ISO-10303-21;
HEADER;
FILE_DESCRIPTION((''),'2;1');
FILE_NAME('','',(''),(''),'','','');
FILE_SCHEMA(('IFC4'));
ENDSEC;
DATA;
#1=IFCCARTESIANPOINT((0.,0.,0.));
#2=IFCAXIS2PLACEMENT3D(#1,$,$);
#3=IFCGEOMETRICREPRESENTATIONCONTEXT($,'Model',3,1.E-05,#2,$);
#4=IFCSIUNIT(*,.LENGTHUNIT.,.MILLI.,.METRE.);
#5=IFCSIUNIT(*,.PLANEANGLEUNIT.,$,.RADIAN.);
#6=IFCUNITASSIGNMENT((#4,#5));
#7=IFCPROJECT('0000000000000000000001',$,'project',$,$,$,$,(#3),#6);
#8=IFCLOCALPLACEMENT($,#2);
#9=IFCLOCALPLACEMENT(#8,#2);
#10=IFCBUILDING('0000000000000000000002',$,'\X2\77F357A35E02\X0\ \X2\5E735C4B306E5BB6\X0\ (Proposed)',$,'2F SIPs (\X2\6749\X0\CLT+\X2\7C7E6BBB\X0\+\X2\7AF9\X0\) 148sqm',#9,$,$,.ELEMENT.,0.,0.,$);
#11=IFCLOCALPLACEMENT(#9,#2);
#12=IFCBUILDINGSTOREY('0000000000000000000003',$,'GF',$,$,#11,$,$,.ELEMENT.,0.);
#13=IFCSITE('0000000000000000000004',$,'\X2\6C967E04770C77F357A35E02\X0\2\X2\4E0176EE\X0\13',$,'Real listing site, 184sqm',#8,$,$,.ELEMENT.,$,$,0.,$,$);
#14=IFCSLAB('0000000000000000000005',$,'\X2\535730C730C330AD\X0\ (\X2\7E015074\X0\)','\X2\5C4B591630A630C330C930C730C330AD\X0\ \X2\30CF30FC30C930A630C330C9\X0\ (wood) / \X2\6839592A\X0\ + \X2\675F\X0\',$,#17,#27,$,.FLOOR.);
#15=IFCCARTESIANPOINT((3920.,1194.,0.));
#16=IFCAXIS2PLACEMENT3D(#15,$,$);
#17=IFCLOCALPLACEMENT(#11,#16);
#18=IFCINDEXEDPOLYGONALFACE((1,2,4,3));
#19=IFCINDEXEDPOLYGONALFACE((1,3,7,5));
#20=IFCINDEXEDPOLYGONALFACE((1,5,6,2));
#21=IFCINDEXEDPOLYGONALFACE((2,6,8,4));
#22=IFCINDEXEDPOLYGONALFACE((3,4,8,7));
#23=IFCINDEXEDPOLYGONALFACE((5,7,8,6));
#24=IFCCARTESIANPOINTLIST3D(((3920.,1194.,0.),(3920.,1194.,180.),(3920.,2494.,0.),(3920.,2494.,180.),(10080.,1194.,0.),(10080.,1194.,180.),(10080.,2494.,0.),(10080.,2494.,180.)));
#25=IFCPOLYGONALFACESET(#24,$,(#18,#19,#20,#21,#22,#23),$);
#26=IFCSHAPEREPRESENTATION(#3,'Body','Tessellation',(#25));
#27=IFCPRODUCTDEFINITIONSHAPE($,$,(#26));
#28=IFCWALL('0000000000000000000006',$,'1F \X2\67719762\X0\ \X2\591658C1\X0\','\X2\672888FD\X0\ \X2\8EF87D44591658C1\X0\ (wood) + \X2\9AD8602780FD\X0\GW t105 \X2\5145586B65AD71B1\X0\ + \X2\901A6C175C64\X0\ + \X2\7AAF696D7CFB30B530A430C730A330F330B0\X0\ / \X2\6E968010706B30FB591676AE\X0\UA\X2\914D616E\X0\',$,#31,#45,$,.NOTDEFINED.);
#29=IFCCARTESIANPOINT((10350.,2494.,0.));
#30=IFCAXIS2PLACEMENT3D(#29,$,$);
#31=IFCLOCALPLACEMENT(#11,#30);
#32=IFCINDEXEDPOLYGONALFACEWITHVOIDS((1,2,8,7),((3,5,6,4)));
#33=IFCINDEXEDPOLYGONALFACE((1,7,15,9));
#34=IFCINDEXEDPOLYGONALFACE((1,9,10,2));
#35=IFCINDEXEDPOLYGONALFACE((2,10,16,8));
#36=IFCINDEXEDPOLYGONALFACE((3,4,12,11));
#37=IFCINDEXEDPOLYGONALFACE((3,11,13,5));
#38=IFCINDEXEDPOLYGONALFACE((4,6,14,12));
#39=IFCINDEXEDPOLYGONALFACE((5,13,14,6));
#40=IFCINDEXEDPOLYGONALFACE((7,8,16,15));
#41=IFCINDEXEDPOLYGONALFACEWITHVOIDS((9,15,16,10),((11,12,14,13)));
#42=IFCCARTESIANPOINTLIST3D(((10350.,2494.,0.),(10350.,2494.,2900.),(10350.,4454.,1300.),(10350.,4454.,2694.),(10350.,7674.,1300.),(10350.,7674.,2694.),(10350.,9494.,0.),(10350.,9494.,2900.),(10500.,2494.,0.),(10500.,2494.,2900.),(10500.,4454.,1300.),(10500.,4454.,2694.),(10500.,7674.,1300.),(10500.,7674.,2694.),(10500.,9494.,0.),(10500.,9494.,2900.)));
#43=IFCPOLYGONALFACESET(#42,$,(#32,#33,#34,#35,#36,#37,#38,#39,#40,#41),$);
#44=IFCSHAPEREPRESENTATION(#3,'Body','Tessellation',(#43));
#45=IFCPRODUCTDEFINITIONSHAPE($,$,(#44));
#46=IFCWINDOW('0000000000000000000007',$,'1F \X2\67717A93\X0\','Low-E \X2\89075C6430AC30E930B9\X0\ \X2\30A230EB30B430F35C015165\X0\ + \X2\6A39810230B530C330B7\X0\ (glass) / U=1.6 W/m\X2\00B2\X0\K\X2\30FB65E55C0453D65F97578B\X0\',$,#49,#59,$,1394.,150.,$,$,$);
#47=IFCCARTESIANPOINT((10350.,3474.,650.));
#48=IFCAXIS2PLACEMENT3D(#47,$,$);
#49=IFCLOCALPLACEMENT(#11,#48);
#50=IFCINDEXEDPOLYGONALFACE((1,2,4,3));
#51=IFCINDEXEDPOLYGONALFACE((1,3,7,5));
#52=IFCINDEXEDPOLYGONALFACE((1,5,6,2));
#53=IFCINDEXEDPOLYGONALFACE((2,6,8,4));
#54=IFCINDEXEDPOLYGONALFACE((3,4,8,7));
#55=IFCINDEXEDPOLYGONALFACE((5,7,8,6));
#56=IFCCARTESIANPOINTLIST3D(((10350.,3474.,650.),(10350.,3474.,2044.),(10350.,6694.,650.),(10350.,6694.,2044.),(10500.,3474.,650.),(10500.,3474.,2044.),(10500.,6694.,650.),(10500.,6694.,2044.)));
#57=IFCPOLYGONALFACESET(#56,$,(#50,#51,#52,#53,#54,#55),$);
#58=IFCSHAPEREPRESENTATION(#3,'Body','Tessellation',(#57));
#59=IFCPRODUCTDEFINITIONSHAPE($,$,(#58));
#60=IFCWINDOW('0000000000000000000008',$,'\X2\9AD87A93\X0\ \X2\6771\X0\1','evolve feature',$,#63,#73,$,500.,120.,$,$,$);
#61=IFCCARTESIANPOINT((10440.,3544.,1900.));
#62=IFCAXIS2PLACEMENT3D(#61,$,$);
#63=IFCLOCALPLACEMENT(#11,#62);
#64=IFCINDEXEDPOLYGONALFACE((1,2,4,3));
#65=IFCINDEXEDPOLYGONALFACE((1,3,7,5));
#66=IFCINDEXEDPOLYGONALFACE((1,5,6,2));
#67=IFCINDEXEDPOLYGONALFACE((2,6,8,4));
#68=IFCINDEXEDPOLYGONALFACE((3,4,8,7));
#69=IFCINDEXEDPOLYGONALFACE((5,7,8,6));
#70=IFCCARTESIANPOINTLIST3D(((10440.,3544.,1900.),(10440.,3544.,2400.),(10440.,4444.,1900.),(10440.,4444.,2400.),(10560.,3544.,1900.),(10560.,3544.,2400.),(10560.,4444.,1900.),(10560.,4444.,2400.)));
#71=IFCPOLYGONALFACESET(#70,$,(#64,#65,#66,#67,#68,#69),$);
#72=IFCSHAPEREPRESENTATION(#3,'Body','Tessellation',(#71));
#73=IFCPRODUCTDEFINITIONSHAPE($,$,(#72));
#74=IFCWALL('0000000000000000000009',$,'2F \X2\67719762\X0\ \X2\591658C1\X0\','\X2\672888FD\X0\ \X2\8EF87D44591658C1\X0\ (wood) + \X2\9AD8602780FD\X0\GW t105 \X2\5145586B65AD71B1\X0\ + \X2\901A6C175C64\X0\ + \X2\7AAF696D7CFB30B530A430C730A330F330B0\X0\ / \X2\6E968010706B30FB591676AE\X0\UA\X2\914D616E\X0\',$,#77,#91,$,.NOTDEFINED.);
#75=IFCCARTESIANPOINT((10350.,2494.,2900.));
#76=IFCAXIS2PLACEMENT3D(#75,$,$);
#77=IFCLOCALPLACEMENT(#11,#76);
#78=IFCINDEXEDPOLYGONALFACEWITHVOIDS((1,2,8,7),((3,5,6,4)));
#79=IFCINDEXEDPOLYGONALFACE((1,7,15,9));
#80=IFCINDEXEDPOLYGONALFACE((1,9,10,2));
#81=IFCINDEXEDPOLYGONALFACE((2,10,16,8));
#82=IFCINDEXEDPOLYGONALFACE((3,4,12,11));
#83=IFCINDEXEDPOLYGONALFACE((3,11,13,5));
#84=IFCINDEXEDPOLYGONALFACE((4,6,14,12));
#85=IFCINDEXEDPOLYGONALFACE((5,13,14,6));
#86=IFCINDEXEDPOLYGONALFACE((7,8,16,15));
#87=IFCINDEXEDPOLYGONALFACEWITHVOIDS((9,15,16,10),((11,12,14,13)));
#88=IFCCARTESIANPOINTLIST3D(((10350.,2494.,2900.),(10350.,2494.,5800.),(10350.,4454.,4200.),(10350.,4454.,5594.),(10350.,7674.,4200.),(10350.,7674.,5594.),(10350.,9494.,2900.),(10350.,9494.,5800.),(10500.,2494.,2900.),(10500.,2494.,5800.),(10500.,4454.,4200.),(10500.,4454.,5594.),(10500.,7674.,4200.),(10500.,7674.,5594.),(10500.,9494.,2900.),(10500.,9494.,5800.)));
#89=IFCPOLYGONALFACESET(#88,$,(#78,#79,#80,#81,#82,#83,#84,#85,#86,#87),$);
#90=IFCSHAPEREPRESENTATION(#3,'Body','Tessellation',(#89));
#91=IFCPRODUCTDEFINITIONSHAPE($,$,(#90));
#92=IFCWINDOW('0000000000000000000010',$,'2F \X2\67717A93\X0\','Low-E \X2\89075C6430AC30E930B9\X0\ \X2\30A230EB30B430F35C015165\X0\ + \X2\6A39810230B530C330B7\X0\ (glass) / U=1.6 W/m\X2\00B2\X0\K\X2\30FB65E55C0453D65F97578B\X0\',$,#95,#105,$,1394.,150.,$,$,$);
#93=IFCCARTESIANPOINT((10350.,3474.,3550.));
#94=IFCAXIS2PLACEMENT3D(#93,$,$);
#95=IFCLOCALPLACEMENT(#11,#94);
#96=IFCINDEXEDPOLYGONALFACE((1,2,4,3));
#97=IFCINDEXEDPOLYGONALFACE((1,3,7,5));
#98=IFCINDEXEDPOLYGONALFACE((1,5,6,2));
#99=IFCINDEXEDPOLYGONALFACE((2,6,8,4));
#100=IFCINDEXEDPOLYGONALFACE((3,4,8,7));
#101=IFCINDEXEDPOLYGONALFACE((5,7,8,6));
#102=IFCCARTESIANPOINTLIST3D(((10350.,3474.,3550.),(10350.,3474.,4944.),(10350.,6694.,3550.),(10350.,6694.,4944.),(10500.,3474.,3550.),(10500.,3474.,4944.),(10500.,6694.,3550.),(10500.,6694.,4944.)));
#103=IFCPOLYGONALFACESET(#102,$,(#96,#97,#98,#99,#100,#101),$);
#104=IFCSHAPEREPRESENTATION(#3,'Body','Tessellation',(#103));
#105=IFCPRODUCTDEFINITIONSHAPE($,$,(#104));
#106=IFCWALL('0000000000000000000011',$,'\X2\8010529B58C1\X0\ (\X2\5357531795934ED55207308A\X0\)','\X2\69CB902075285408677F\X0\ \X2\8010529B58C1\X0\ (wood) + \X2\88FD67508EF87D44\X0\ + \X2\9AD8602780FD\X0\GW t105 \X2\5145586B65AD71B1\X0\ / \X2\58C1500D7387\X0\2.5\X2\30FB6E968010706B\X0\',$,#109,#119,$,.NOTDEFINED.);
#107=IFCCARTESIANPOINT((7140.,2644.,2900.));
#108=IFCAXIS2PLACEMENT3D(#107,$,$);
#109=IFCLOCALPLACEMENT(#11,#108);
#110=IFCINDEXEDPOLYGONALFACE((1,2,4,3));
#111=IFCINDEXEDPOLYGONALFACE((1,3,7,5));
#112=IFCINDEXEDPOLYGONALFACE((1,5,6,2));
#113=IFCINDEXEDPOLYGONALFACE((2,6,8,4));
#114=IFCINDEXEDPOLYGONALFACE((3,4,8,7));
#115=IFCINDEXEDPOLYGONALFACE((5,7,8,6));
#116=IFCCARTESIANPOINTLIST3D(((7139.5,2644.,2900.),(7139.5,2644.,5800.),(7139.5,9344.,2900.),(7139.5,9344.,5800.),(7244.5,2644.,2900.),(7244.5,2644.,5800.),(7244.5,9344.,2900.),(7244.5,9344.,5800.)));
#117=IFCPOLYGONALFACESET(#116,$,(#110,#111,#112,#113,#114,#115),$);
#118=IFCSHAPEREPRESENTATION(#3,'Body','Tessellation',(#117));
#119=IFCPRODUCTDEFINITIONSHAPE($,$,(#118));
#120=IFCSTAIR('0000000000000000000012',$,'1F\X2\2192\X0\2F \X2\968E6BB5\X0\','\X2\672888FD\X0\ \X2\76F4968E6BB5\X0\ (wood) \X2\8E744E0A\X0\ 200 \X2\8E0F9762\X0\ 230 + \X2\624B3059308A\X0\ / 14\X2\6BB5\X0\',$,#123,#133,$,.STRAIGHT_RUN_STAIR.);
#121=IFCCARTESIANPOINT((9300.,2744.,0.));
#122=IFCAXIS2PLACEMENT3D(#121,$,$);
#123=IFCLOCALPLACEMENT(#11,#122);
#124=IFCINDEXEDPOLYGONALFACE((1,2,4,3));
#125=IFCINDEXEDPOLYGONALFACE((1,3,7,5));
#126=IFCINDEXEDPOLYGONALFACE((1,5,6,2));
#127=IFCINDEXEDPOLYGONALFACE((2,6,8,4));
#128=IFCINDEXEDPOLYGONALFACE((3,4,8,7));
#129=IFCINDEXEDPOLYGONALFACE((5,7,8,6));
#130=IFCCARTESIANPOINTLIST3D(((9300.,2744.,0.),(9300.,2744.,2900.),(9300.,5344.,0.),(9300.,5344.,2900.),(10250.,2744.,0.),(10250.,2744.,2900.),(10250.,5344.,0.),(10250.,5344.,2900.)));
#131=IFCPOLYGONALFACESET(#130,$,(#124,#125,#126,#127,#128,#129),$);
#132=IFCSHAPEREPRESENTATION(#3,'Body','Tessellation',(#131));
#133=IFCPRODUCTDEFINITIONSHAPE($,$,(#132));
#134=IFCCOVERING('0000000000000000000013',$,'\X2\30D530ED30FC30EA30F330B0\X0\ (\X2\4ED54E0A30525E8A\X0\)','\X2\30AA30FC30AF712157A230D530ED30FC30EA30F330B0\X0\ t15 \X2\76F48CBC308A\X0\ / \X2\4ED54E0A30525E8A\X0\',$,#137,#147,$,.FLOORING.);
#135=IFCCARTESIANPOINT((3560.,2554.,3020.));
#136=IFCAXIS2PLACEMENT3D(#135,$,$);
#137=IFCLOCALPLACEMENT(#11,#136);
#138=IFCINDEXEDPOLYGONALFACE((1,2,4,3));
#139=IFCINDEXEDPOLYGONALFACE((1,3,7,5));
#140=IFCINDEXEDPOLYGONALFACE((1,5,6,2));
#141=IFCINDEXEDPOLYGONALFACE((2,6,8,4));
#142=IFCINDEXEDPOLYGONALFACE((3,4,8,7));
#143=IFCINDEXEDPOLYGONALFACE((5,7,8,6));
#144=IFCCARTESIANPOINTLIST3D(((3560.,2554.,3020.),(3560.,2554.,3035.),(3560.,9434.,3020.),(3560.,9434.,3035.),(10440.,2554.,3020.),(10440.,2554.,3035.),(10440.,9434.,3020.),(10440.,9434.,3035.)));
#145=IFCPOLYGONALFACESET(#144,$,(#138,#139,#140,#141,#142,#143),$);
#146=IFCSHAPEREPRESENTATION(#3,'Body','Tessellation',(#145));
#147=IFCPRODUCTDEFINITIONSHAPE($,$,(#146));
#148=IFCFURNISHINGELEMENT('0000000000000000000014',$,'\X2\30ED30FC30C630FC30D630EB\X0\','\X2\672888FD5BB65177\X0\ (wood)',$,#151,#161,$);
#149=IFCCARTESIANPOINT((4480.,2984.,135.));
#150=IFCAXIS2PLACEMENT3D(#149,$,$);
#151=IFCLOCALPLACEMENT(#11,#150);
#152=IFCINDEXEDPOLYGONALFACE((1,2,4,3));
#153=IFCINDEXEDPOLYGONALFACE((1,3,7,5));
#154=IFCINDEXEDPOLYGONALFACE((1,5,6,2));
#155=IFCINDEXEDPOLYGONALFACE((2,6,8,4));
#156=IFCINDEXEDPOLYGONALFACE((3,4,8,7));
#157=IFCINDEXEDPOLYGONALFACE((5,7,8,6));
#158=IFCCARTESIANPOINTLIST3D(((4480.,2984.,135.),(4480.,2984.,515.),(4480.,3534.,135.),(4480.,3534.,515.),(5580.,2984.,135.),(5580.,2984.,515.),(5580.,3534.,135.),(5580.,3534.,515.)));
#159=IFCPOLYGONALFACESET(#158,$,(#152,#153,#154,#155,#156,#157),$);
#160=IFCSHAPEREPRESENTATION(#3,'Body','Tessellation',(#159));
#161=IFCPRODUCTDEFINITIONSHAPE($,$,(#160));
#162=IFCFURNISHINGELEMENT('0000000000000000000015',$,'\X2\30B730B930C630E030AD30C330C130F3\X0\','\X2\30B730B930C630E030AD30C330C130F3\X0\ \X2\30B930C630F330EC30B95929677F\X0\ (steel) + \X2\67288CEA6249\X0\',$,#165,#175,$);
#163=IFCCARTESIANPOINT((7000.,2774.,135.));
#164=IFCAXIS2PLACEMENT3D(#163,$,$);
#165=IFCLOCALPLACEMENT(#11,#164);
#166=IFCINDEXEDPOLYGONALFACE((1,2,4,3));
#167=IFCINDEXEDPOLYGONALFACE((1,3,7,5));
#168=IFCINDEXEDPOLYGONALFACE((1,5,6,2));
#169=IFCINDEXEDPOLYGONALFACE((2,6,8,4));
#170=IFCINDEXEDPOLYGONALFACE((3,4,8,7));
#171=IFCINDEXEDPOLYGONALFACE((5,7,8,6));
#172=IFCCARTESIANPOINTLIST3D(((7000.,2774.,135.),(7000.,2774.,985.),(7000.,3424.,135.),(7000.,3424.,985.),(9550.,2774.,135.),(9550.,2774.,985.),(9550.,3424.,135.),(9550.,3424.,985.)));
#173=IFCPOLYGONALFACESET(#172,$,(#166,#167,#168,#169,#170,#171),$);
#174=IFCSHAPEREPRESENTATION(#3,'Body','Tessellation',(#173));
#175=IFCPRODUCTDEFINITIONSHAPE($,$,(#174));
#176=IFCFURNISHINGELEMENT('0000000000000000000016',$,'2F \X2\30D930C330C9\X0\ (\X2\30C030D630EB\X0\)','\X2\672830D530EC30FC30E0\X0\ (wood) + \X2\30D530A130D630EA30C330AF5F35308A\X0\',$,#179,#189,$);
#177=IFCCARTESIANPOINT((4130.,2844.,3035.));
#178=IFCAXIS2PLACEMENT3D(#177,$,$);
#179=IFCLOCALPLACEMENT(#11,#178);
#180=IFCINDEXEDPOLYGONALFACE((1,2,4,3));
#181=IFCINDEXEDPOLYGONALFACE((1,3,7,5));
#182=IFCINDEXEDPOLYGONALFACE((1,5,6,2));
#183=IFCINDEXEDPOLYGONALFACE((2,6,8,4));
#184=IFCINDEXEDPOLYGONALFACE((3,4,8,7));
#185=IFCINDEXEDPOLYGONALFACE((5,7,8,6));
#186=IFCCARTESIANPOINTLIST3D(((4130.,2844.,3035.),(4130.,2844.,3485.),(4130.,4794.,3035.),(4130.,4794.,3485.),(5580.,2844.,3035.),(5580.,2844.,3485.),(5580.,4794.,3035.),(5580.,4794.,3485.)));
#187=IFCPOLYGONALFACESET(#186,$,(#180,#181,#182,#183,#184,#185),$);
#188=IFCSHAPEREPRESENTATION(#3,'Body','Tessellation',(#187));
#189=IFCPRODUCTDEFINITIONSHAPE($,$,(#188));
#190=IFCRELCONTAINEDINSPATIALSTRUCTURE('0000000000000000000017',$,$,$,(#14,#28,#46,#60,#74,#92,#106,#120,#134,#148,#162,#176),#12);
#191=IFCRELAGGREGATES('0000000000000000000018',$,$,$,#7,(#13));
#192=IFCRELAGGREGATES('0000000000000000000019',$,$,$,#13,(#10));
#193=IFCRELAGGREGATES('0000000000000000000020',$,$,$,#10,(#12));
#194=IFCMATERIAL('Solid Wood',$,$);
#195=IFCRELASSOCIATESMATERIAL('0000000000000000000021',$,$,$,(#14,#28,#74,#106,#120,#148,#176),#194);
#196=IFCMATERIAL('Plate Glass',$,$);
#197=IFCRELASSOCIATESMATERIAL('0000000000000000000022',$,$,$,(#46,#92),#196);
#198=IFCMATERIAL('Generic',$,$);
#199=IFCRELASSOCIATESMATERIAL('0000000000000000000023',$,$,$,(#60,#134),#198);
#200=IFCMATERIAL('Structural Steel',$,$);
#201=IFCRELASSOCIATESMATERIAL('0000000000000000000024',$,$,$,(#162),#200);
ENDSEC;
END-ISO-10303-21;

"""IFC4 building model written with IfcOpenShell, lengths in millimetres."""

from ifc_helpers import new_model, si_unit, frame, frame_2d, origin, place, context, project, spatial, rectangle, extrude, material, element, fill, save


model = new_model("IFC4")

# Units and contexts
model_context = context("Model", 3, precision=1e-05, world=origin())
ifc_project = project(units=[si_unit("LENGTHUNIT", "METRE", prefix="MILLI"), si_unit("PLANEANGLEUNIT", "RADIAN")], contexts=[model_context])

# Site, building, storey
site_placement = place(None, origin())
site = spatial("IfcSite", under=ifc_project, at=site_placement, Name="沖縄県石垣市2丁目13", ObjectType="Real listing site, 184sqm", CompositionType="ELEMENT", RefElevation=0.0)
building_placement = place(site_placement, origin())
building = spatial("IfcBuilding", under=site, at=building_placement, Name="石垣市 平屋の家 (Proposed)", ObjectType="2F SIPs (杉CLT+籾殻+竹) 148sqm", CompositionType="ELEMENT", ElevationOfRefHeight=0.0, ElevationOfTerrain=0.0)
storey_placement = place(building_placement, origin())
storey = spatial("IfcBuildingStorey", under=building, at=storey_placement, Name="GF", CompositionType="ELEMENT", Elevation=0.0)

# Slab
ifc_material_1 = material(Name="Solid Wood")
slab_placement = place(storey_placement, frame((3920.0, 1194.0, 0.0)))
element("IfcSlab", 1, at=slab_placement, inside=storey, material=ifc_material_1, Name="南デッキ (縁側)", Description="屋外ウッドデッキ ハードウッド (wood) / 根太 + 束", PredefinedType="FLOOR", context=model_context, shape_type="SweptSolid", body=[
    extrude(rectangle(XDim=6160.0, YDim=1300.0, at=frame_2d((3080.0, 650.0))), frame((3920.0, 1194.0, 0.0)), (0.0, 0.0, 1.0), 180.0),
])

# Wall, openings, windows
wall_1_placement = place(storey_placement, frame((10350.0, 2494.0, 0.0)))
wall_1 = element("IfcWall", 2, at=wall_1_placement, inside=storey, material=ifc_material_1, Name="1F 東面 外壁", Description="木製 軸組外壁 (wood) + 高性能GW t105 充填断熱 + 通気層 + 窯業系サイディング / 準耐火・外皮UA配慮", PredefinedType="NOTDEFINED", context=model_context, shape_type="SweptSolid", body=[
    extrude(rectangle(XDim=150.0, YDim=7000.0, at=frame_2d((75.0, 3500.0))), frame((10350.0, 2494.0, 0.0)), (0.0, 0.0, 1.0), 2900.0),
])
opening_1_placement = place(storey_placement, frame((10350.0, 3474.0, 650.0)))
opening_1 = element("IfcOpeningElement", 3, at=opening_1_placement, cuts=wall_1, PredefinedType="NOTDEFINED", context=model_context, shape_type="SweptSolid", body=[
    extrude(rectangle(XDim=150.0, YDim=3220.0, at=frame_2d((75.0, 1610.0))), frame((10350.0, 3474.0, 650.0)), (0.0, 0.0, 1.0), 1394.0),
])
opening_2_placement = place(storey_placement, frame((10440.0, 3544.0, 1900.0)))
opening_2 = element("IfcOpeningElement", 4, at=opening_2_placement, cuts=wall_1, PredefinedType="NOTDEFINED", context=model_context, shape_type="SweptSolid", body=[
    extrude(rectangle(XDim=120.0, YDim=900.0, at=frame_2d((60.0, 450.0))), frame((10440.0, 3544.0, 1900.0)), (0.0, 0.0, 1.0), 500.0),
])
ifc_material_2 = material(Name="Plate Glass")
window_1_placement = place(storey_placement, frame((10350.0, 3474.0, 650.0)))
window_1 = element("IfcWindow", 5, at=window_1_placement, inside=storey, material=ifc_material_2, Name="1F 東窓", Description="Low-E 複層ガラス アルゴン封入 + 樹脂サッシ (glass) / U=1.6 W/m²K・日射取得型", OverallHeight=1394.0, OverallWidth=150.0, context=model_context, shape_type="SweptSolid", body=[
    extrude(rectangle(XDim=150.0, YDim=3220.0, at=frame_2d((75.0, 1610.0))), frame((10350.0, 3474.0, 650.0)), (0.0, 0.0, 1.0), 1394.0),
])
fill(opening_1, window_1)
ifc_material_3 = material(Name="Generic")
window_2_placement = place(storey_placement, frame((10440.0, 3544.0, 1900.0)))
window_2 = element("IfcWindow", 6, at=window_2_placement, inside=storey, material=ifc_material_3, Name="高窓 東1", Description="evolve feature", OverallHeight=500.0, OverallWidth=120.0, context=model_context, shape_type="SweptSolid", body=[
    extrude(rectangle(XDim=120.0, YDim=900.0, at=frame_2d((60.0, 450.0))), frame((10440.0, 3544.0, 1900.0)), (0.0, 0.0, 1.0), 500.0),
])
fill(opening_2, window_2)

# Wall, opening, window
wall_2_placement = place(storey_placement, frame((10350.0, 2494.0, 2900.0)))
wall_2 = element("IfcWall", 7, at=wall_2_placement, inside=storey, material=ifc_material_1, Name="2F 東面 外壁", Description="木製 軸組外壁 (wood) + 高性能GW t105 充填断熱 + 通気層 + 窯業系サイディング / 準耐火・外皮UA配慮", PredefinedType="NOTDEFINED", context=model_context, shape_type="SweptSolid", body=[
    extrude(rectangle(XDim=150.0, YDim=7000.0, at=frame_2d((75.0, 3500.0))), frame((10350.0, 2494.0, 2900.0)), (0.0, 0.0, 1.0), 2900.0),
])
opening_3_placement = place(storey_placement, frame((10350.0, 3474.0, 3550.0)))
opening_3 = element("IfcOpeningElement", 8, at=opening_3_placement, cuts=wall_2, PredefinedType="NOTDEFINED", context=model_context, shape_type="SweptSolid", body=[
    extrude(rectangle(XDim=150.0, YDim=3220.0, at=frame_2d((75.0, 1610.0))), frame((10350.0, 3474.0, 3550.0)), (0.0, 0.0, 1.0), 1394.0),
])
window_3_placement = place(storey_placement, frame((10350.0, 3474.0, 3550.0)))
window_3 = element("IfcWindow", 9, at=window_3_placement, inside=storey, material=ifc_material_2, Name="2F 東窓", Description="Low-E 複層ガラス アルゴン封入 + 樹脂サッシ (glass) / U=1.6 W/m²K・日射取得型", OverallHeight=1394.0, OverallWidth=150.0, context=model_context, shape_type="SweptSolid", body=[
    extrude(rectangle(XDim=150.0, YDim=3220.0, at=frame_2d((75.0, 1610.0))), frame((10350.0, 3474.0, 3550.0)), (0.0, 0.0, 1.0), 1394.0),
])
fill(opening_3, window_3)

# Wall
wall_3_placement = place(storey_placement, frame((7140.0, 2644.0, 2900.0)))
element("IfcWall", 10, at=wall_3_placement, inside=storey, material=ifc_material_1, Name="耐力壁 (南北間仕切り)", Description="構造用合板 耐力壁 (wood) + 製材軸組 + 高性能GW t105 充填断熱 / 壁倍率2.5・準耐火", PredefinedType="NOTDEFINED", context=model_context, shape_type="SweptSolid", body=[
    extrude(rectangle(XDim=105.0, YDim=6700.0, at=frame_2d((52.0, 3350.0))), frame((7140.0, 2644.0, 2900.0)), (0.0, 0.0, 1.0), 2900.0),
])

# Stair
stair_placement = place(storey_placement, frame((9300.0, 2744.0, 0.0)))
element("IfcStair", 11, at=stair_placement, inside=storey, material=ifc_material_1, Name="1F→2F 階段", Description="木製 直階段 (wood) 蹴上 200 踏面 230 + 手すり / 14段", PredefinedType="STRAIGHT_RUN_STAIR", context=model_context, shape_type="SweptSolid", body=[
    extrude(rectangle(XDim=950.0, YDim=2600.0, at=frame_2d((475.0, 1300.0))), frame((9300.0, 2744.0, 0.0)), (0.0, 0.0, 1.0), 2900.0),
])

# Covering
covering_placement = place(storey_placement, frame((3560.0, 2554.0, 3020.0)))
element("IfcCovering", 12, at=covering_placement, inside=storey, material=ifc_material_3, Name="フローリング (仕上げ床)", Description="オーク無垢フローリング t15 直貼り / 仕上げ床", PredefinedType="FLOORING", context=model_context, shape_type="SweptSolid", body=[
    extrude(rectangle(XDim=6880.0, YDim=6880.0, at=frame_2d((3440.0, 3440.0))), frame((3560.0, 2554.0, 3020.0)), (0.0, 0.0, 1.0), 15.0),
])

# Furnishing elements
furnishing_1_placement = place(storey_placement, frame((4480.0, 2984.0, 135.0)))
element("IfcFurnishingElement", 13, at=furnishing_1_placement, inside=storey, material=ifc_material_1, Name="ローテーブル", Description="木製家具 (wood)", context=model_context, shape_type="SweptSolid", body=[
    extrude(rectangle(XDim=1100.0, YDim=550.0, at=frame_2d((550.0, 275.0))), frame((4480.0, 2984.0, 135.0)), (0.0, 0.0, 1.0), 380.0),
])
ifc_material_4 = material(Name="Structural Steel")
furnishing_2_placement = place(storey_placement, frame((7000.0, 2774.0, 135.0)))
element("IfcFurnishingElement", 14, at=furnishing_2_placement, inside=storey, material=ifc_material_4, Name="システムキッチン", Description="システムキッチン ステンレス天板 (steel) + 木質扉", context=model_context, shape_type="SweptSolid", body=[
    extrude(rectangle(XDim=2550.0, YDim=650.0, at=frame_2d((1275.0, 325.0))), frame((7000.0, 2774.0, 135.0)), (0.0, 0.0, 1.0), 850.0),
])
furnishing_3_placement = place(storey_placement, frame((4130.0, 2844.0, 3035.0)))
element("IfcFurnishingElement", 15, at=furnishing_3_placement, inside=storey, material=ifc_material_1, Name="2F ベッド (ダブル)", Description="木フレーム (wood) + ファブリック張り", context=model_context, shape_type="SweptSolid", body=[
    extrude(rectangle(XDim=1450.0, YDim=1950.0, at=frame_2d((725.0, 975.0))), frame((4130.0, 2844.0, 3035.0)), (0.0, 0.0, 1.0), 450.0),
])

save(model, "model.ifc")
